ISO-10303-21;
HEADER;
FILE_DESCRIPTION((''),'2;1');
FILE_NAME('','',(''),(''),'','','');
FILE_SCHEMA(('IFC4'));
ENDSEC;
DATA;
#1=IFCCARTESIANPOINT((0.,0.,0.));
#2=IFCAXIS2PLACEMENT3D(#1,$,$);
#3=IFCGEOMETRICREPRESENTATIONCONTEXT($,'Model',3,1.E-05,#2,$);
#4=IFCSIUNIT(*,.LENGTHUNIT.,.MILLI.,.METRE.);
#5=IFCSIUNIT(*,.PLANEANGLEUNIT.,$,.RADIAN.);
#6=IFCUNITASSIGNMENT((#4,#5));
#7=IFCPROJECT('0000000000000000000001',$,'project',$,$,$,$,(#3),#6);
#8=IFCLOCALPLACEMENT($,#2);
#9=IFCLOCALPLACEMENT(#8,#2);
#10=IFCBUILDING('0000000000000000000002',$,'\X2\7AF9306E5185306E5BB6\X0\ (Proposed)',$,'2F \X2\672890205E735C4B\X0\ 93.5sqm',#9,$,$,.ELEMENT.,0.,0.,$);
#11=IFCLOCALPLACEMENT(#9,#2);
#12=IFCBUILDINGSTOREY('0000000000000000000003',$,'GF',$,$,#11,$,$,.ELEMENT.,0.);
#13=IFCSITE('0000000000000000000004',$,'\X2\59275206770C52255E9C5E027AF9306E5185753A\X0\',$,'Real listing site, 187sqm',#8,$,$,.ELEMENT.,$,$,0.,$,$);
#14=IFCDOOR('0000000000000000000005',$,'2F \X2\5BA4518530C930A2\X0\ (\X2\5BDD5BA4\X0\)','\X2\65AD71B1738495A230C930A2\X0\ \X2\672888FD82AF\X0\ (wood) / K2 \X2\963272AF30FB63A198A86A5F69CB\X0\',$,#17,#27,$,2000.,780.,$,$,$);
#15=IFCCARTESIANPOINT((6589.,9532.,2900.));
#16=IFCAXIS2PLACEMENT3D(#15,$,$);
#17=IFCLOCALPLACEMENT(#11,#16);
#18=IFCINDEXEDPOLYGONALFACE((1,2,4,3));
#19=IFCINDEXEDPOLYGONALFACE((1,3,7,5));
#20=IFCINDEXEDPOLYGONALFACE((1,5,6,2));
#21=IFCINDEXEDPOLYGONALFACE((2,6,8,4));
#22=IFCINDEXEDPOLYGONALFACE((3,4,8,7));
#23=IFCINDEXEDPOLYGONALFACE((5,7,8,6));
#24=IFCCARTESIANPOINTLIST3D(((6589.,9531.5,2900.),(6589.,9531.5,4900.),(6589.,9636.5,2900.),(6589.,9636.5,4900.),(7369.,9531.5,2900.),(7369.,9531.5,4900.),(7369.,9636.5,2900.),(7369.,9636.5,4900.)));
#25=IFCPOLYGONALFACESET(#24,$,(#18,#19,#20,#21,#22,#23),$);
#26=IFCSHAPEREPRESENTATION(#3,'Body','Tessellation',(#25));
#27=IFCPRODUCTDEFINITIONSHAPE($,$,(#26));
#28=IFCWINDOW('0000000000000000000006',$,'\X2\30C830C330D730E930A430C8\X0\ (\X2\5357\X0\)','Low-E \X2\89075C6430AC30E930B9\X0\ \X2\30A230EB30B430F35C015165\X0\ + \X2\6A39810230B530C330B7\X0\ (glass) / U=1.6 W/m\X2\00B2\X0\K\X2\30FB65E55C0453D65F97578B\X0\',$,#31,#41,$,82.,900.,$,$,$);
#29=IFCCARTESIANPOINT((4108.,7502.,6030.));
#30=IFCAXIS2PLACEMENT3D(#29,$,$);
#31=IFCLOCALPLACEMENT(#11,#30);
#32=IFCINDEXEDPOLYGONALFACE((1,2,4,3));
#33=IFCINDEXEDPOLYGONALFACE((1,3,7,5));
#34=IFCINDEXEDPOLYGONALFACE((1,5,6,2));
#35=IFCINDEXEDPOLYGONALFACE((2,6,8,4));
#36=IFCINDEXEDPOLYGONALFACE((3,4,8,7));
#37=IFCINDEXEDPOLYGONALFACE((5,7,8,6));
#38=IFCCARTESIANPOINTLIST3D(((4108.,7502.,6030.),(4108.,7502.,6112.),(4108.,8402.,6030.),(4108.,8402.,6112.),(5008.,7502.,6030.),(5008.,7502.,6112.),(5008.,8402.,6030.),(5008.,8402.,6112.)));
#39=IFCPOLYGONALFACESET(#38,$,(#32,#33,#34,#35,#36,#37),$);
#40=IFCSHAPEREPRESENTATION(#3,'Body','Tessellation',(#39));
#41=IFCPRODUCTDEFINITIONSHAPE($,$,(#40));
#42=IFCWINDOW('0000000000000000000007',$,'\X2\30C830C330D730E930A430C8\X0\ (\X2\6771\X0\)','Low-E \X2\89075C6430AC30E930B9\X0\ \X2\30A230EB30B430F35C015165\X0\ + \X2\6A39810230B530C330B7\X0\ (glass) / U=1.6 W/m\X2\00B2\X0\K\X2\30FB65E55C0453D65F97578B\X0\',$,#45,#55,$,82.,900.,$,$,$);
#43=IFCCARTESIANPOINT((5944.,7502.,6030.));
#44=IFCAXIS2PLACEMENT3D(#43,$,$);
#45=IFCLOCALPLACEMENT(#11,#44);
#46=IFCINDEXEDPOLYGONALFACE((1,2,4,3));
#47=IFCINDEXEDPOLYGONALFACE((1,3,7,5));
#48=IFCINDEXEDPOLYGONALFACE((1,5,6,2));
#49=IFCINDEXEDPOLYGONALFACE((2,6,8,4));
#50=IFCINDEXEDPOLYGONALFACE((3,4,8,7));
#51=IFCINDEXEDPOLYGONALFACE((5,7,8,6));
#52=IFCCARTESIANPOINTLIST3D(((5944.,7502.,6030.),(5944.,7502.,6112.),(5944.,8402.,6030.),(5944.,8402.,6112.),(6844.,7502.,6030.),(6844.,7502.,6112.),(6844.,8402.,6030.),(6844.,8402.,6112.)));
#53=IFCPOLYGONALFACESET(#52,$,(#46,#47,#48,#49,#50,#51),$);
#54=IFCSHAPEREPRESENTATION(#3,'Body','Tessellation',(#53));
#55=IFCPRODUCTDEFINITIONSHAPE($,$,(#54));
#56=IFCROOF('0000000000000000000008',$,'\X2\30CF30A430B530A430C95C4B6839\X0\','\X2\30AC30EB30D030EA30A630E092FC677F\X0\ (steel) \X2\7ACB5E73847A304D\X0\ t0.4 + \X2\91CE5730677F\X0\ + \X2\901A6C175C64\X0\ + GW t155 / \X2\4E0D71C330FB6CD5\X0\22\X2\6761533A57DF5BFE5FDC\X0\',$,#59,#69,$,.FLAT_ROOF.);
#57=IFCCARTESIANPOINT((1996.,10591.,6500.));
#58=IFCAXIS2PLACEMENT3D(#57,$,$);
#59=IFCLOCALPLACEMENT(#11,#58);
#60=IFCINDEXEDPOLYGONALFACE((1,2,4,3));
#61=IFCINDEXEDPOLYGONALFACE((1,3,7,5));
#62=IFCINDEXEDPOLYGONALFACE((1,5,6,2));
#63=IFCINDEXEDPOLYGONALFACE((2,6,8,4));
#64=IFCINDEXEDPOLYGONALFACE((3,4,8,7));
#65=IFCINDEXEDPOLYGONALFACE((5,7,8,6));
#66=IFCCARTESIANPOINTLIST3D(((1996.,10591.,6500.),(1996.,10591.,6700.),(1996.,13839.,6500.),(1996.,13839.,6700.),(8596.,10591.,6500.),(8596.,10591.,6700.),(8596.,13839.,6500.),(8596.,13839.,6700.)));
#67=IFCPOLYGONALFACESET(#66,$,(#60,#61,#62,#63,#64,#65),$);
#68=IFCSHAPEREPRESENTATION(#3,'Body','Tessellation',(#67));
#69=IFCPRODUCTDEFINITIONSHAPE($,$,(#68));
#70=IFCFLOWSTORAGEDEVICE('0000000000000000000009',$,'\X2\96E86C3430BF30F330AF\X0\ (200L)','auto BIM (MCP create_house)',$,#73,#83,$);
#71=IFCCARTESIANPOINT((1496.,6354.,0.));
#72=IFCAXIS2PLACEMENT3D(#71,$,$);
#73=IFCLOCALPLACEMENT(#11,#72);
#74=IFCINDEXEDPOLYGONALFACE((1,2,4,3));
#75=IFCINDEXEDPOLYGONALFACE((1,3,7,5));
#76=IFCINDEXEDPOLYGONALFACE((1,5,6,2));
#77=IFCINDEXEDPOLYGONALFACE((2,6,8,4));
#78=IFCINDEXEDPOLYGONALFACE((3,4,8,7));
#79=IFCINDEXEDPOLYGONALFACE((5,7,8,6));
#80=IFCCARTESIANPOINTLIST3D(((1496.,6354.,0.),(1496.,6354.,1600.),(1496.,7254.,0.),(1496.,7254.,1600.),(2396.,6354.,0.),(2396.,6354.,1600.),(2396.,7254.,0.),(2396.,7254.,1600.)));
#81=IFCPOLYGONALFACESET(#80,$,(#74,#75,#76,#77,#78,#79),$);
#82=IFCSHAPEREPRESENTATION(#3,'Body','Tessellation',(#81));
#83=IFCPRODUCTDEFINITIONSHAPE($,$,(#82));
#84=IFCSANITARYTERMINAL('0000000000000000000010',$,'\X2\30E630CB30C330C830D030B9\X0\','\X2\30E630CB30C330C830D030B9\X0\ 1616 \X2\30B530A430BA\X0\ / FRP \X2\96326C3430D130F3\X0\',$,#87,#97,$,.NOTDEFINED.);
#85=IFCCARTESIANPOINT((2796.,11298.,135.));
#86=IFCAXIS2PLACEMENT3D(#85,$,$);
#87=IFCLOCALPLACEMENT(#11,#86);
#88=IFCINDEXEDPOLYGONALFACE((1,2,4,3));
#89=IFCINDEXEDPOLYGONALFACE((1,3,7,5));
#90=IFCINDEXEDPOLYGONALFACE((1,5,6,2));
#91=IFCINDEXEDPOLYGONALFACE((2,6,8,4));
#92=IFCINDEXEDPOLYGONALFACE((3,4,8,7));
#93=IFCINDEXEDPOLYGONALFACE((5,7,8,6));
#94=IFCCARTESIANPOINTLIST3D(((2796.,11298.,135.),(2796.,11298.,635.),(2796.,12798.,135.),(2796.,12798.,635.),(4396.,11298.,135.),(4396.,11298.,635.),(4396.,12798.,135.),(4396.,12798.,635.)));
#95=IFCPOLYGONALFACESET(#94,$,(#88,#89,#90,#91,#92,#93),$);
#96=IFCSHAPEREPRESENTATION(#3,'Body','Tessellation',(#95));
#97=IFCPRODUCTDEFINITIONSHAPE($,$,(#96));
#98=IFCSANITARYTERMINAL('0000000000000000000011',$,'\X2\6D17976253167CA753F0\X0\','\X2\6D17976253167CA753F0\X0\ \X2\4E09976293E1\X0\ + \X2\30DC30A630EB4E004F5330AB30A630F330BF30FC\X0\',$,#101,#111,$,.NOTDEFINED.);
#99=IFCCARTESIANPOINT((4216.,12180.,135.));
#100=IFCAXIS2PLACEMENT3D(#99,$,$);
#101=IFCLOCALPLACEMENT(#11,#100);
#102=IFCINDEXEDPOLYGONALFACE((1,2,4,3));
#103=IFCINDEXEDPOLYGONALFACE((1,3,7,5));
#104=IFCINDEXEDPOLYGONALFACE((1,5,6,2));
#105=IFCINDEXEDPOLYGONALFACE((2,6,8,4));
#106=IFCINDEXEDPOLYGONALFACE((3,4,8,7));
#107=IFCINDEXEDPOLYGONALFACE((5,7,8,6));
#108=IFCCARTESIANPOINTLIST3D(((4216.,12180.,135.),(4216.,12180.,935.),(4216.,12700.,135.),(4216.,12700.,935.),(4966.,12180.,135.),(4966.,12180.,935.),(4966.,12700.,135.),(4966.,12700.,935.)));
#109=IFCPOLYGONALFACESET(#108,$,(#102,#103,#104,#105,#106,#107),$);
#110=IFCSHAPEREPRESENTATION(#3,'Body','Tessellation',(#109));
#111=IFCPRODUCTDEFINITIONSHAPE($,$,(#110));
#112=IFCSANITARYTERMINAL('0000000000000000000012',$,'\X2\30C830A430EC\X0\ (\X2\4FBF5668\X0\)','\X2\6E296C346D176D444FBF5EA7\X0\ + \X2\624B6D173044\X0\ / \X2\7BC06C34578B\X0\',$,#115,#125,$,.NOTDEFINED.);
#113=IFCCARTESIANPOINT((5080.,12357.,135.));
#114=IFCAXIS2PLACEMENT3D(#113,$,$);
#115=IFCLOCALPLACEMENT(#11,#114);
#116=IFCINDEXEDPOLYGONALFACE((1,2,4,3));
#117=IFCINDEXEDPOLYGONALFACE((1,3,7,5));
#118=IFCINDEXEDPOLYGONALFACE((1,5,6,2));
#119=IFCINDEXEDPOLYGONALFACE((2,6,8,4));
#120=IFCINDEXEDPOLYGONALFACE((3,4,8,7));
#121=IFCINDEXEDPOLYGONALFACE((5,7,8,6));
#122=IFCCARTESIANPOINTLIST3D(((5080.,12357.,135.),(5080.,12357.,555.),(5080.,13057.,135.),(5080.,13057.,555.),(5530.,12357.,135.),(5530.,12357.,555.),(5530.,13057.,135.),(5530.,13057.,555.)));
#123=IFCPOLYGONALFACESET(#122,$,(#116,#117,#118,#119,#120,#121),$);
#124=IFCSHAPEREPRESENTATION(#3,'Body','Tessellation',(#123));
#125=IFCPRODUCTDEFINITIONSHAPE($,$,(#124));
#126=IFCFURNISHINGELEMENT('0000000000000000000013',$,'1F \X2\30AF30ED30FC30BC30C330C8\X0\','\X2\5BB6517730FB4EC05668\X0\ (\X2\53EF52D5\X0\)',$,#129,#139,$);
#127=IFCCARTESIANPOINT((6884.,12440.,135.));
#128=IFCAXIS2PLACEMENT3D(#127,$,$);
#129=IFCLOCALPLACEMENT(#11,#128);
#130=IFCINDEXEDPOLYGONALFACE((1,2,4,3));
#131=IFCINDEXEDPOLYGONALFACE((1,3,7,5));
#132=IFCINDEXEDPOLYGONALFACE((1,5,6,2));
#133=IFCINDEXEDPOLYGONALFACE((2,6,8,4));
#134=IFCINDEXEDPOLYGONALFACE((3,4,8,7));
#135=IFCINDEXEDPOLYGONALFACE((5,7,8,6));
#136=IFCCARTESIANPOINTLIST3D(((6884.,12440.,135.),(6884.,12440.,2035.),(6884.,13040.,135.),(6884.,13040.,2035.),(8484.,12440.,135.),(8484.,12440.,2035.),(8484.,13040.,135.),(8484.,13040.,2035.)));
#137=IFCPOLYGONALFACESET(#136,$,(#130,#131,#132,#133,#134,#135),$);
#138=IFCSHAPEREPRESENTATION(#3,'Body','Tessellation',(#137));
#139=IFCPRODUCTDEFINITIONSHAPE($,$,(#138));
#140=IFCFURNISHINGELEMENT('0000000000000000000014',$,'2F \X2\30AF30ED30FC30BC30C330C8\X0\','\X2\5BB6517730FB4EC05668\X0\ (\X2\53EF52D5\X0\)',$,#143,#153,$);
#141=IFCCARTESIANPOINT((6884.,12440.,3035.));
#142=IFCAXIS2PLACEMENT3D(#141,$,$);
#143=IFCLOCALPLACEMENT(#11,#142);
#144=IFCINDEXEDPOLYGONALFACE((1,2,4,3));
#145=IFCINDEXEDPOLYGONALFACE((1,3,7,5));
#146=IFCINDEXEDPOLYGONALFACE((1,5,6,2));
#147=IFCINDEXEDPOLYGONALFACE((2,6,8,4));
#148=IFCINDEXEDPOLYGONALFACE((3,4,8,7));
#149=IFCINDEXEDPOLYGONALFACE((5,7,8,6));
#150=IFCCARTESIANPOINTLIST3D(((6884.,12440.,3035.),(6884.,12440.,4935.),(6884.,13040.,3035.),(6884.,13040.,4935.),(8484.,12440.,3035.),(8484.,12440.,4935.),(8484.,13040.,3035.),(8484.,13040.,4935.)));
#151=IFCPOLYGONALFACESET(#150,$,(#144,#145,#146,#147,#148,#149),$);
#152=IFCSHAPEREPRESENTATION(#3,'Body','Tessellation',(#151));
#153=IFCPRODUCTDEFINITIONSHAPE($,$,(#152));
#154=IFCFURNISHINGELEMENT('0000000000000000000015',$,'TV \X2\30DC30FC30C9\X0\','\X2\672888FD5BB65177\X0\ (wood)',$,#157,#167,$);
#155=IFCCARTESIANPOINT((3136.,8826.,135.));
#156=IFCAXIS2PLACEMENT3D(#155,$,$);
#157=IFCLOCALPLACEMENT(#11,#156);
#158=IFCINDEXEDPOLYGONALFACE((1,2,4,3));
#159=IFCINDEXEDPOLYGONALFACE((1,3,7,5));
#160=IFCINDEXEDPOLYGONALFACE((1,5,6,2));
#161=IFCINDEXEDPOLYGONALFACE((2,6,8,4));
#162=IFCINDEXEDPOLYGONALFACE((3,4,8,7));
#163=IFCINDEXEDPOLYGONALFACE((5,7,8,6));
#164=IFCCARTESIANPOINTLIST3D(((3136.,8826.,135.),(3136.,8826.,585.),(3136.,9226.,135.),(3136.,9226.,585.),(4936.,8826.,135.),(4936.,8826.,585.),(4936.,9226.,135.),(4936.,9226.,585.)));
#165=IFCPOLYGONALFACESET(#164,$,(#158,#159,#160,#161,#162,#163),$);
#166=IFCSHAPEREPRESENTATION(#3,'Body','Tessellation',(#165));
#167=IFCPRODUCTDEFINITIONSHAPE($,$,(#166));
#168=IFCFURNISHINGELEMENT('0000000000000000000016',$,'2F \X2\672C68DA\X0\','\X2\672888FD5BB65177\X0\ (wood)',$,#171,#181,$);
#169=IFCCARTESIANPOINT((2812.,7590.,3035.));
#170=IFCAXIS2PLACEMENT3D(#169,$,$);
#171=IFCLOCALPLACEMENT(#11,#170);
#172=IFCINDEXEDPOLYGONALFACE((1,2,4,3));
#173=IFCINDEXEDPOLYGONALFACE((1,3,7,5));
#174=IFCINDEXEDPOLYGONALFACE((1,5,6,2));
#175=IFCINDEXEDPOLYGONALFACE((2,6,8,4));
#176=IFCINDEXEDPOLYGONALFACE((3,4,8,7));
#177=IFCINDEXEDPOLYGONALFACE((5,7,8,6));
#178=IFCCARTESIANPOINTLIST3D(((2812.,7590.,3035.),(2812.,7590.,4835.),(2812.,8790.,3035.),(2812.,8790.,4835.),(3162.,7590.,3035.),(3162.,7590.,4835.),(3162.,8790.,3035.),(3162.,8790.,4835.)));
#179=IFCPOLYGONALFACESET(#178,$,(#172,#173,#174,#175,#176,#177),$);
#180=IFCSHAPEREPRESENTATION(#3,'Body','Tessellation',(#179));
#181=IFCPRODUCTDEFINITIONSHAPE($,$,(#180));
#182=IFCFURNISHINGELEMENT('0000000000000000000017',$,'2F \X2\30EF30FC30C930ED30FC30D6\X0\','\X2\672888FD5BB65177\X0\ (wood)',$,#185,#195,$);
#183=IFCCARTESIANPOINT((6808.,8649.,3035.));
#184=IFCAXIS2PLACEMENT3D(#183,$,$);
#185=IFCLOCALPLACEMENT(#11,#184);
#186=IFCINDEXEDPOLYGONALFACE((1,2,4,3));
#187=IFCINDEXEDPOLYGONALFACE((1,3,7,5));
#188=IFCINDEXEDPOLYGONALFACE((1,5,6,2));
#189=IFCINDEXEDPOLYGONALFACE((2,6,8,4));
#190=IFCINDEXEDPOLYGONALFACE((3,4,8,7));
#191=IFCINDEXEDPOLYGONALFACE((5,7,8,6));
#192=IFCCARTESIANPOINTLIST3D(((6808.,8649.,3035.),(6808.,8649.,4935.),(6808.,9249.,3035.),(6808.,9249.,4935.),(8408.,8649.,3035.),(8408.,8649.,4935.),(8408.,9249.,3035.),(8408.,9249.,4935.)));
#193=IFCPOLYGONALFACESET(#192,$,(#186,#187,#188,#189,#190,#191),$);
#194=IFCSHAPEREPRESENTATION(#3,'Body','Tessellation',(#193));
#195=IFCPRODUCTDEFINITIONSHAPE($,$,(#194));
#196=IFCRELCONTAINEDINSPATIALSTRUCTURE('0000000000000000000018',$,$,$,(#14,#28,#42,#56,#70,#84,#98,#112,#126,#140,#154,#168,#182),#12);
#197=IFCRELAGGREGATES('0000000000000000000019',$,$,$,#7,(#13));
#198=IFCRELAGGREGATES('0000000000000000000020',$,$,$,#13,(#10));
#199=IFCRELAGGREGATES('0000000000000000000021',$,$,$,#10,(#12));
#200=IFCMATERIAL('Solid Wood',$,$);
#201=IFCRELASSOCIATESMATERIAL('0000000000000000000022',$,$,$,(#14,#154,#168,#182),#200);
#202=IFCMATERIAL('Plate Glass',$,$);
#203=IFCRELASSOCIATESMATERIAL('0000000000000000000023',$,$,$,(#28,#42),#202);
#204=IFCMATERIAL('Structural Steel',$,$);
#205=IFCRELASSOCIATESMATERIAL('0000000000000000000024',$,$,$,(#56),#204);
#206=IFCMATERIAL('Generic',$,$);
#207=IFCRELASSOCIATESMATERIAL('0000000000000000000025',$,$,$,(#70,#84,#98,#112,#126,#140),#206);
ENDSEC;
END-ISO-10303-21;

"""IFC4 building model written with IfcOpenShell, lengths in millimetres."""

from ifc_helpers import new_model, si_unit, frame, frame_2d, origin, place, context, project, spatial, rectangle, extrude, material, element, save


model = new_model("IFC4")

# Units and contexts
model_context = context("Model", 3, precision=1e-05, world=origin())
ifc_project = project(units=[si_unit("LENGTHUNIT", "METRE", prefix="MILLI"), si_unit("PLANEANGLEUNIT", "RADIAN")], contexts=[model_context])

# Site, building, storey
site_placement = place(None, origin())
site = spatial("IfcSite", under=ifc_project, at=site_placement, Name="大分県別府市竹の内町", ObjectType="Real listing site, 187sqm", CompositionType="ELEMENT", RefElevation=0.0)
building_placement = place(site_placement, origin())
building = spatial("IfcBuilding", under=site, at=building_placement, Name="竹の内の家 (Proposed)", ObjectType="2F 木造平屋 93.5sqm", CompositionType="ELEMENT", ElevationOfRefHeight=0.0, ElevationOfTerrain=0.0)
storey_placement = place(building_placement, origin())
storey = spatial("IfcBuildingStorey", under=building, at=storey_placement, Name="GF", CompositionType="ELEMENT", Elevation=0.0)

# Shared definitions
ifc_material_1 = material(Name="Solid Wood")
ifc_material_2 = material(Name="Plate Glass")

# Door
door_1_placement = place(storey_placement, frame((6589.0, 9532.0, 2900.0)))
element("IfcDoor", 1, at=door_1_placement, inside=storey, material=ifc_material_1, Name="2F 室内ドア (寝室)", Description="断熱玄関ドア 木製芯 (wood) / K2 防犯・採風機構", OverallHeight=2000.0, OverallWidth=780.0, context=model_context, shape_type="SweptSolid", body=[
    extrude(rectangle(XDim=780.0, YDim=105.0, at=frame_2d((390.0, 52.0))), frame((6589.0, 9532.0, 2900.0)), (0.0, 0.0, 1.0), 2000.0),
])

# Windows
window_1_placement = place(storey_placement, frame((4108.0, 7502.0, 6030.0)))
element("IfcWindow", 2, at=window_1_placement, inside=storey, material=ifc_material_2, Name="トップライト (南)", Description="Low-E 複層ガラス アルゴン封入 + 樹脂サッシ (glass) / U=1.6 W/m²K・日射取得型", OverallHeight=82.0, OverallWidth=900.0, context=model_context, shape_type="SweptSolid", body=[
    extrude(rectangle(XDim=900.0, YDim=900.0, at=frame_2d((450.0, 450.0))), frame((4108.0, 7502.0, 6030.0)), (0.0, 0.0, 1.0), 82.0),
])
window_2_placement = place(storey_placement, frame((5944.0, 7502.0, 6030.0)))
element("IfcWindow", 3, at=window_2_placement, inside=storey, material=ifc_material_2, Name="トップライト (東)", Description="Low-E 複層ガラス アルゴン封入 + 樹脂サッシ (glass) / U=1.6 W/m²K・日射取得型", OverallHeight=82.0, OverallWidth=900.0, context=model_context, shape_type="SweptSolid", body=[
    extrude(rectangle(XDim=900.0, YDim=900.0, at=frame_2d((450.0, 450.0))), frame((5944.0, 7502.0, 6030.0)), (0.0, 0.0, 1.0), 82.0),
])

# Roof
ifc_material_3 = material(Name="Structural Steel")
roof_placement = place(storey_placement, frame((1996.0, 10591.0, 6500.0)))
element("IfcRoof", 4, at=roof_placement, inside=storey, material=ifc_material_3, Name="ハイサイド屋根", Description="ガルバリウム鋼板 (steel) 立平葺き t0.4 + 野地板 + 通気層 + GW t155 / 不燃・法22条区域対応", PredefinedType="FLAT_ROOF", context=model_context, shape_type="SweptSolid", body=[
    extrude(rectangle(XDim=6600.0, YDim=3248.0, at=frame_2d((3300.0, 1624.0))), frame((1996.0, 10591.0, 6500.0)), (0.0, 0.0, 1.0), 200.0),
])

# Flow storage device
ifc_material_4 = material(Name="Generic")
flow_storage_device_placement = place(storey_placement, frame((1496.0, 6354.0, 0.0)))
element("IfcFlowStorageDevice", 5, at=flow_storage_device_placement, inside=storey, material=ifc_material_4, Name="雨水タンク (200L)", Description="auto BIM (MCP create_house)", context=model_context, shape_type="SweptSolid", body=[
    extrude(rectangle(XDim=900.0, YDim=900.0, at=frame_2d((450.0, 450.0))), frame((1496.0, 6354.0, 0.0)), (0.0, 0.0, 1.0), 1600.0),
])

# Sanitary terminals
sanitary_terminal_1_placement = place(storey_placement, frame((2796.0, 11298.0, 135.0)))
element("IfcSanitaryTerminal", 6, at=sanitary_terminal_1_placement, inside=storey, material=ifc_material_4, Name="ユニットバス", Description="ユニットバス 1616 サイズ / FRP 防水パン", PredefinedType="NOTDEFINED", context=model_context, shape_type="SweptSolid", body=[
    extrude(rectangle(XDim=1600.0, YDim=1500.0, at=frame_2d((800.0, 750.0))), frame((2796.0, 11298.0, 135.0)), (0.0, 0.0, 1.0), 500.0),
])
sanitary_terminal_2_placement = place(storey_placement, frame((4216.0, 12180.0, 135.0)))
element("IfcSanitaryTerminal", 7, at=sanitary_terminal_2_placement, inside=storey, material=ifc_material_4, Name="洗面化粧台", Description="洗面化粧台 三面鏡 + ボウル一体カウンター", PredefinedType="NOTDEFINED", context=model_context, shape_type="SweptSolid", body=[
    extrude(rectangle(XDim=750.0, YDim=520.0, at=frame_2d((375.0, 260.0))), frame((4216.0, 12180.0, 135.0)), (0.0, 0.0, 1.0), 800.0),
])
sanitary_terminal_3_placement = place(storey_placement, frame((5080.0, 12357.0, 135.0)))
element("IfcSanitaryTerminal", 8, at=sanitary_terminal_3_placement, inside=storey, material=ifc_material_4, Name="トイレ (便器)", Description="温水洗浄便座 + 手洗い / 節水型", PredefinedType="NOTDEFINED", context=model_context, shape_type="SweptSolid", body=[
    extrude(rectangle(XDim=450.0, YDim=700.0, at=frame_2d((225.0, 350.0))), frame((5080.0, 12357.0, 135.0)), (0.0, 0.0, 1.0), 420.0),
])

# Furnishing elements
furnishing_1_placement = place(storey_placement, frame((6884.0, 12440.0, 135.0)))
element("IfcFurnishingElement", 9, at=furnishing_1_placement, inside=storey, material=ifc_material_4, Name="1F クローゼット", Description="家具・什器 (可動)", context=model_context, shape_type="SweptSolid", body=[
    extrude(rectangle(XDim=1600.0, YDim=600.0, at=frame_2d((800.0, 300.0))), frame((6884.0, 12440.0, 135.0)), (0.0, 0.0, 1.0), 1900.0),
])
furnishing_2_placement = place(storey_placement, frame((6884.0, 12440.0, 3035.0)))
element("IfcFurnishingElement", 10, at=furnishing_2_placement, inside=storey, material=ifc_material_4, Name="2F クローゼット", Description="家具・什器 (可動)", context=model_context, shape_type="SweptSolid", body=[
    extrude(rectangle(XDim=1600.0, YDim=600.0, at=frame_2d((800.0, 300.0))), frame((6884.0, 12440.0, 3035.0)), (0.0, 0.0, 1.0), 1900.0),
])
furnishing_3_placement = place(storey_placement, frame((3136.0, 8826.0, 135.0)))
element("IfcFurnishingElement", 11, at=furnishing_3_placement, inside=storey, material=ifc_material_1, Name="TV ボード", Description="木製家具 (wood)", context=model_context, shape_type="SweptSolid", body=[
    extrude(rectangle(XDim=1800.0, YDim=400.0, at=frame_2d((900.0, 200.0))), frame((3136.0, 8826.0, 135.0)), (0.0, 0.0, 1.0), 450.0),
])
furnishing_4_placement = place(storey_placement, frame((2812.0, 7590.0, 3035.0)))
element("IfcFurnishingElement", 12, at=furnishing_4_placement, inside=storey, material=ifc_material_1, Name="2F 本棚", Description="木製家具 (wood)", context=model_context, shape_type="SweptSolid", body=[
    extrude(rectangle(XDim=350.0, YDim=1200.0, at=frame_2d((175.0, 600.0))), frame((2812.0, 7590.0, 3035.0)), (0.0, 0.0, 1.0), 1800.0),
])
furnishing_5_placement = place(storey_placement, frame((6808.0, 8649.0, 3035.0)))
element("IfcFurnishingElement", 13, at=furnishing_5_placement, inside=storey, material=ifc_material_1, Name="2F ワードローブ", Description="木製家具 (wood)", context=model_context, shape_type="SweptSolid", body=[
    extrude(rectangle(XDim=1600.0, YDim=600.0, at=frame_2d((800.0, 300.0))), frame((6808.0, 8649.0, 3035.0)), (0.0, 0.0, 1.0), 1900.0),
])

save(model, "model.ifc")
